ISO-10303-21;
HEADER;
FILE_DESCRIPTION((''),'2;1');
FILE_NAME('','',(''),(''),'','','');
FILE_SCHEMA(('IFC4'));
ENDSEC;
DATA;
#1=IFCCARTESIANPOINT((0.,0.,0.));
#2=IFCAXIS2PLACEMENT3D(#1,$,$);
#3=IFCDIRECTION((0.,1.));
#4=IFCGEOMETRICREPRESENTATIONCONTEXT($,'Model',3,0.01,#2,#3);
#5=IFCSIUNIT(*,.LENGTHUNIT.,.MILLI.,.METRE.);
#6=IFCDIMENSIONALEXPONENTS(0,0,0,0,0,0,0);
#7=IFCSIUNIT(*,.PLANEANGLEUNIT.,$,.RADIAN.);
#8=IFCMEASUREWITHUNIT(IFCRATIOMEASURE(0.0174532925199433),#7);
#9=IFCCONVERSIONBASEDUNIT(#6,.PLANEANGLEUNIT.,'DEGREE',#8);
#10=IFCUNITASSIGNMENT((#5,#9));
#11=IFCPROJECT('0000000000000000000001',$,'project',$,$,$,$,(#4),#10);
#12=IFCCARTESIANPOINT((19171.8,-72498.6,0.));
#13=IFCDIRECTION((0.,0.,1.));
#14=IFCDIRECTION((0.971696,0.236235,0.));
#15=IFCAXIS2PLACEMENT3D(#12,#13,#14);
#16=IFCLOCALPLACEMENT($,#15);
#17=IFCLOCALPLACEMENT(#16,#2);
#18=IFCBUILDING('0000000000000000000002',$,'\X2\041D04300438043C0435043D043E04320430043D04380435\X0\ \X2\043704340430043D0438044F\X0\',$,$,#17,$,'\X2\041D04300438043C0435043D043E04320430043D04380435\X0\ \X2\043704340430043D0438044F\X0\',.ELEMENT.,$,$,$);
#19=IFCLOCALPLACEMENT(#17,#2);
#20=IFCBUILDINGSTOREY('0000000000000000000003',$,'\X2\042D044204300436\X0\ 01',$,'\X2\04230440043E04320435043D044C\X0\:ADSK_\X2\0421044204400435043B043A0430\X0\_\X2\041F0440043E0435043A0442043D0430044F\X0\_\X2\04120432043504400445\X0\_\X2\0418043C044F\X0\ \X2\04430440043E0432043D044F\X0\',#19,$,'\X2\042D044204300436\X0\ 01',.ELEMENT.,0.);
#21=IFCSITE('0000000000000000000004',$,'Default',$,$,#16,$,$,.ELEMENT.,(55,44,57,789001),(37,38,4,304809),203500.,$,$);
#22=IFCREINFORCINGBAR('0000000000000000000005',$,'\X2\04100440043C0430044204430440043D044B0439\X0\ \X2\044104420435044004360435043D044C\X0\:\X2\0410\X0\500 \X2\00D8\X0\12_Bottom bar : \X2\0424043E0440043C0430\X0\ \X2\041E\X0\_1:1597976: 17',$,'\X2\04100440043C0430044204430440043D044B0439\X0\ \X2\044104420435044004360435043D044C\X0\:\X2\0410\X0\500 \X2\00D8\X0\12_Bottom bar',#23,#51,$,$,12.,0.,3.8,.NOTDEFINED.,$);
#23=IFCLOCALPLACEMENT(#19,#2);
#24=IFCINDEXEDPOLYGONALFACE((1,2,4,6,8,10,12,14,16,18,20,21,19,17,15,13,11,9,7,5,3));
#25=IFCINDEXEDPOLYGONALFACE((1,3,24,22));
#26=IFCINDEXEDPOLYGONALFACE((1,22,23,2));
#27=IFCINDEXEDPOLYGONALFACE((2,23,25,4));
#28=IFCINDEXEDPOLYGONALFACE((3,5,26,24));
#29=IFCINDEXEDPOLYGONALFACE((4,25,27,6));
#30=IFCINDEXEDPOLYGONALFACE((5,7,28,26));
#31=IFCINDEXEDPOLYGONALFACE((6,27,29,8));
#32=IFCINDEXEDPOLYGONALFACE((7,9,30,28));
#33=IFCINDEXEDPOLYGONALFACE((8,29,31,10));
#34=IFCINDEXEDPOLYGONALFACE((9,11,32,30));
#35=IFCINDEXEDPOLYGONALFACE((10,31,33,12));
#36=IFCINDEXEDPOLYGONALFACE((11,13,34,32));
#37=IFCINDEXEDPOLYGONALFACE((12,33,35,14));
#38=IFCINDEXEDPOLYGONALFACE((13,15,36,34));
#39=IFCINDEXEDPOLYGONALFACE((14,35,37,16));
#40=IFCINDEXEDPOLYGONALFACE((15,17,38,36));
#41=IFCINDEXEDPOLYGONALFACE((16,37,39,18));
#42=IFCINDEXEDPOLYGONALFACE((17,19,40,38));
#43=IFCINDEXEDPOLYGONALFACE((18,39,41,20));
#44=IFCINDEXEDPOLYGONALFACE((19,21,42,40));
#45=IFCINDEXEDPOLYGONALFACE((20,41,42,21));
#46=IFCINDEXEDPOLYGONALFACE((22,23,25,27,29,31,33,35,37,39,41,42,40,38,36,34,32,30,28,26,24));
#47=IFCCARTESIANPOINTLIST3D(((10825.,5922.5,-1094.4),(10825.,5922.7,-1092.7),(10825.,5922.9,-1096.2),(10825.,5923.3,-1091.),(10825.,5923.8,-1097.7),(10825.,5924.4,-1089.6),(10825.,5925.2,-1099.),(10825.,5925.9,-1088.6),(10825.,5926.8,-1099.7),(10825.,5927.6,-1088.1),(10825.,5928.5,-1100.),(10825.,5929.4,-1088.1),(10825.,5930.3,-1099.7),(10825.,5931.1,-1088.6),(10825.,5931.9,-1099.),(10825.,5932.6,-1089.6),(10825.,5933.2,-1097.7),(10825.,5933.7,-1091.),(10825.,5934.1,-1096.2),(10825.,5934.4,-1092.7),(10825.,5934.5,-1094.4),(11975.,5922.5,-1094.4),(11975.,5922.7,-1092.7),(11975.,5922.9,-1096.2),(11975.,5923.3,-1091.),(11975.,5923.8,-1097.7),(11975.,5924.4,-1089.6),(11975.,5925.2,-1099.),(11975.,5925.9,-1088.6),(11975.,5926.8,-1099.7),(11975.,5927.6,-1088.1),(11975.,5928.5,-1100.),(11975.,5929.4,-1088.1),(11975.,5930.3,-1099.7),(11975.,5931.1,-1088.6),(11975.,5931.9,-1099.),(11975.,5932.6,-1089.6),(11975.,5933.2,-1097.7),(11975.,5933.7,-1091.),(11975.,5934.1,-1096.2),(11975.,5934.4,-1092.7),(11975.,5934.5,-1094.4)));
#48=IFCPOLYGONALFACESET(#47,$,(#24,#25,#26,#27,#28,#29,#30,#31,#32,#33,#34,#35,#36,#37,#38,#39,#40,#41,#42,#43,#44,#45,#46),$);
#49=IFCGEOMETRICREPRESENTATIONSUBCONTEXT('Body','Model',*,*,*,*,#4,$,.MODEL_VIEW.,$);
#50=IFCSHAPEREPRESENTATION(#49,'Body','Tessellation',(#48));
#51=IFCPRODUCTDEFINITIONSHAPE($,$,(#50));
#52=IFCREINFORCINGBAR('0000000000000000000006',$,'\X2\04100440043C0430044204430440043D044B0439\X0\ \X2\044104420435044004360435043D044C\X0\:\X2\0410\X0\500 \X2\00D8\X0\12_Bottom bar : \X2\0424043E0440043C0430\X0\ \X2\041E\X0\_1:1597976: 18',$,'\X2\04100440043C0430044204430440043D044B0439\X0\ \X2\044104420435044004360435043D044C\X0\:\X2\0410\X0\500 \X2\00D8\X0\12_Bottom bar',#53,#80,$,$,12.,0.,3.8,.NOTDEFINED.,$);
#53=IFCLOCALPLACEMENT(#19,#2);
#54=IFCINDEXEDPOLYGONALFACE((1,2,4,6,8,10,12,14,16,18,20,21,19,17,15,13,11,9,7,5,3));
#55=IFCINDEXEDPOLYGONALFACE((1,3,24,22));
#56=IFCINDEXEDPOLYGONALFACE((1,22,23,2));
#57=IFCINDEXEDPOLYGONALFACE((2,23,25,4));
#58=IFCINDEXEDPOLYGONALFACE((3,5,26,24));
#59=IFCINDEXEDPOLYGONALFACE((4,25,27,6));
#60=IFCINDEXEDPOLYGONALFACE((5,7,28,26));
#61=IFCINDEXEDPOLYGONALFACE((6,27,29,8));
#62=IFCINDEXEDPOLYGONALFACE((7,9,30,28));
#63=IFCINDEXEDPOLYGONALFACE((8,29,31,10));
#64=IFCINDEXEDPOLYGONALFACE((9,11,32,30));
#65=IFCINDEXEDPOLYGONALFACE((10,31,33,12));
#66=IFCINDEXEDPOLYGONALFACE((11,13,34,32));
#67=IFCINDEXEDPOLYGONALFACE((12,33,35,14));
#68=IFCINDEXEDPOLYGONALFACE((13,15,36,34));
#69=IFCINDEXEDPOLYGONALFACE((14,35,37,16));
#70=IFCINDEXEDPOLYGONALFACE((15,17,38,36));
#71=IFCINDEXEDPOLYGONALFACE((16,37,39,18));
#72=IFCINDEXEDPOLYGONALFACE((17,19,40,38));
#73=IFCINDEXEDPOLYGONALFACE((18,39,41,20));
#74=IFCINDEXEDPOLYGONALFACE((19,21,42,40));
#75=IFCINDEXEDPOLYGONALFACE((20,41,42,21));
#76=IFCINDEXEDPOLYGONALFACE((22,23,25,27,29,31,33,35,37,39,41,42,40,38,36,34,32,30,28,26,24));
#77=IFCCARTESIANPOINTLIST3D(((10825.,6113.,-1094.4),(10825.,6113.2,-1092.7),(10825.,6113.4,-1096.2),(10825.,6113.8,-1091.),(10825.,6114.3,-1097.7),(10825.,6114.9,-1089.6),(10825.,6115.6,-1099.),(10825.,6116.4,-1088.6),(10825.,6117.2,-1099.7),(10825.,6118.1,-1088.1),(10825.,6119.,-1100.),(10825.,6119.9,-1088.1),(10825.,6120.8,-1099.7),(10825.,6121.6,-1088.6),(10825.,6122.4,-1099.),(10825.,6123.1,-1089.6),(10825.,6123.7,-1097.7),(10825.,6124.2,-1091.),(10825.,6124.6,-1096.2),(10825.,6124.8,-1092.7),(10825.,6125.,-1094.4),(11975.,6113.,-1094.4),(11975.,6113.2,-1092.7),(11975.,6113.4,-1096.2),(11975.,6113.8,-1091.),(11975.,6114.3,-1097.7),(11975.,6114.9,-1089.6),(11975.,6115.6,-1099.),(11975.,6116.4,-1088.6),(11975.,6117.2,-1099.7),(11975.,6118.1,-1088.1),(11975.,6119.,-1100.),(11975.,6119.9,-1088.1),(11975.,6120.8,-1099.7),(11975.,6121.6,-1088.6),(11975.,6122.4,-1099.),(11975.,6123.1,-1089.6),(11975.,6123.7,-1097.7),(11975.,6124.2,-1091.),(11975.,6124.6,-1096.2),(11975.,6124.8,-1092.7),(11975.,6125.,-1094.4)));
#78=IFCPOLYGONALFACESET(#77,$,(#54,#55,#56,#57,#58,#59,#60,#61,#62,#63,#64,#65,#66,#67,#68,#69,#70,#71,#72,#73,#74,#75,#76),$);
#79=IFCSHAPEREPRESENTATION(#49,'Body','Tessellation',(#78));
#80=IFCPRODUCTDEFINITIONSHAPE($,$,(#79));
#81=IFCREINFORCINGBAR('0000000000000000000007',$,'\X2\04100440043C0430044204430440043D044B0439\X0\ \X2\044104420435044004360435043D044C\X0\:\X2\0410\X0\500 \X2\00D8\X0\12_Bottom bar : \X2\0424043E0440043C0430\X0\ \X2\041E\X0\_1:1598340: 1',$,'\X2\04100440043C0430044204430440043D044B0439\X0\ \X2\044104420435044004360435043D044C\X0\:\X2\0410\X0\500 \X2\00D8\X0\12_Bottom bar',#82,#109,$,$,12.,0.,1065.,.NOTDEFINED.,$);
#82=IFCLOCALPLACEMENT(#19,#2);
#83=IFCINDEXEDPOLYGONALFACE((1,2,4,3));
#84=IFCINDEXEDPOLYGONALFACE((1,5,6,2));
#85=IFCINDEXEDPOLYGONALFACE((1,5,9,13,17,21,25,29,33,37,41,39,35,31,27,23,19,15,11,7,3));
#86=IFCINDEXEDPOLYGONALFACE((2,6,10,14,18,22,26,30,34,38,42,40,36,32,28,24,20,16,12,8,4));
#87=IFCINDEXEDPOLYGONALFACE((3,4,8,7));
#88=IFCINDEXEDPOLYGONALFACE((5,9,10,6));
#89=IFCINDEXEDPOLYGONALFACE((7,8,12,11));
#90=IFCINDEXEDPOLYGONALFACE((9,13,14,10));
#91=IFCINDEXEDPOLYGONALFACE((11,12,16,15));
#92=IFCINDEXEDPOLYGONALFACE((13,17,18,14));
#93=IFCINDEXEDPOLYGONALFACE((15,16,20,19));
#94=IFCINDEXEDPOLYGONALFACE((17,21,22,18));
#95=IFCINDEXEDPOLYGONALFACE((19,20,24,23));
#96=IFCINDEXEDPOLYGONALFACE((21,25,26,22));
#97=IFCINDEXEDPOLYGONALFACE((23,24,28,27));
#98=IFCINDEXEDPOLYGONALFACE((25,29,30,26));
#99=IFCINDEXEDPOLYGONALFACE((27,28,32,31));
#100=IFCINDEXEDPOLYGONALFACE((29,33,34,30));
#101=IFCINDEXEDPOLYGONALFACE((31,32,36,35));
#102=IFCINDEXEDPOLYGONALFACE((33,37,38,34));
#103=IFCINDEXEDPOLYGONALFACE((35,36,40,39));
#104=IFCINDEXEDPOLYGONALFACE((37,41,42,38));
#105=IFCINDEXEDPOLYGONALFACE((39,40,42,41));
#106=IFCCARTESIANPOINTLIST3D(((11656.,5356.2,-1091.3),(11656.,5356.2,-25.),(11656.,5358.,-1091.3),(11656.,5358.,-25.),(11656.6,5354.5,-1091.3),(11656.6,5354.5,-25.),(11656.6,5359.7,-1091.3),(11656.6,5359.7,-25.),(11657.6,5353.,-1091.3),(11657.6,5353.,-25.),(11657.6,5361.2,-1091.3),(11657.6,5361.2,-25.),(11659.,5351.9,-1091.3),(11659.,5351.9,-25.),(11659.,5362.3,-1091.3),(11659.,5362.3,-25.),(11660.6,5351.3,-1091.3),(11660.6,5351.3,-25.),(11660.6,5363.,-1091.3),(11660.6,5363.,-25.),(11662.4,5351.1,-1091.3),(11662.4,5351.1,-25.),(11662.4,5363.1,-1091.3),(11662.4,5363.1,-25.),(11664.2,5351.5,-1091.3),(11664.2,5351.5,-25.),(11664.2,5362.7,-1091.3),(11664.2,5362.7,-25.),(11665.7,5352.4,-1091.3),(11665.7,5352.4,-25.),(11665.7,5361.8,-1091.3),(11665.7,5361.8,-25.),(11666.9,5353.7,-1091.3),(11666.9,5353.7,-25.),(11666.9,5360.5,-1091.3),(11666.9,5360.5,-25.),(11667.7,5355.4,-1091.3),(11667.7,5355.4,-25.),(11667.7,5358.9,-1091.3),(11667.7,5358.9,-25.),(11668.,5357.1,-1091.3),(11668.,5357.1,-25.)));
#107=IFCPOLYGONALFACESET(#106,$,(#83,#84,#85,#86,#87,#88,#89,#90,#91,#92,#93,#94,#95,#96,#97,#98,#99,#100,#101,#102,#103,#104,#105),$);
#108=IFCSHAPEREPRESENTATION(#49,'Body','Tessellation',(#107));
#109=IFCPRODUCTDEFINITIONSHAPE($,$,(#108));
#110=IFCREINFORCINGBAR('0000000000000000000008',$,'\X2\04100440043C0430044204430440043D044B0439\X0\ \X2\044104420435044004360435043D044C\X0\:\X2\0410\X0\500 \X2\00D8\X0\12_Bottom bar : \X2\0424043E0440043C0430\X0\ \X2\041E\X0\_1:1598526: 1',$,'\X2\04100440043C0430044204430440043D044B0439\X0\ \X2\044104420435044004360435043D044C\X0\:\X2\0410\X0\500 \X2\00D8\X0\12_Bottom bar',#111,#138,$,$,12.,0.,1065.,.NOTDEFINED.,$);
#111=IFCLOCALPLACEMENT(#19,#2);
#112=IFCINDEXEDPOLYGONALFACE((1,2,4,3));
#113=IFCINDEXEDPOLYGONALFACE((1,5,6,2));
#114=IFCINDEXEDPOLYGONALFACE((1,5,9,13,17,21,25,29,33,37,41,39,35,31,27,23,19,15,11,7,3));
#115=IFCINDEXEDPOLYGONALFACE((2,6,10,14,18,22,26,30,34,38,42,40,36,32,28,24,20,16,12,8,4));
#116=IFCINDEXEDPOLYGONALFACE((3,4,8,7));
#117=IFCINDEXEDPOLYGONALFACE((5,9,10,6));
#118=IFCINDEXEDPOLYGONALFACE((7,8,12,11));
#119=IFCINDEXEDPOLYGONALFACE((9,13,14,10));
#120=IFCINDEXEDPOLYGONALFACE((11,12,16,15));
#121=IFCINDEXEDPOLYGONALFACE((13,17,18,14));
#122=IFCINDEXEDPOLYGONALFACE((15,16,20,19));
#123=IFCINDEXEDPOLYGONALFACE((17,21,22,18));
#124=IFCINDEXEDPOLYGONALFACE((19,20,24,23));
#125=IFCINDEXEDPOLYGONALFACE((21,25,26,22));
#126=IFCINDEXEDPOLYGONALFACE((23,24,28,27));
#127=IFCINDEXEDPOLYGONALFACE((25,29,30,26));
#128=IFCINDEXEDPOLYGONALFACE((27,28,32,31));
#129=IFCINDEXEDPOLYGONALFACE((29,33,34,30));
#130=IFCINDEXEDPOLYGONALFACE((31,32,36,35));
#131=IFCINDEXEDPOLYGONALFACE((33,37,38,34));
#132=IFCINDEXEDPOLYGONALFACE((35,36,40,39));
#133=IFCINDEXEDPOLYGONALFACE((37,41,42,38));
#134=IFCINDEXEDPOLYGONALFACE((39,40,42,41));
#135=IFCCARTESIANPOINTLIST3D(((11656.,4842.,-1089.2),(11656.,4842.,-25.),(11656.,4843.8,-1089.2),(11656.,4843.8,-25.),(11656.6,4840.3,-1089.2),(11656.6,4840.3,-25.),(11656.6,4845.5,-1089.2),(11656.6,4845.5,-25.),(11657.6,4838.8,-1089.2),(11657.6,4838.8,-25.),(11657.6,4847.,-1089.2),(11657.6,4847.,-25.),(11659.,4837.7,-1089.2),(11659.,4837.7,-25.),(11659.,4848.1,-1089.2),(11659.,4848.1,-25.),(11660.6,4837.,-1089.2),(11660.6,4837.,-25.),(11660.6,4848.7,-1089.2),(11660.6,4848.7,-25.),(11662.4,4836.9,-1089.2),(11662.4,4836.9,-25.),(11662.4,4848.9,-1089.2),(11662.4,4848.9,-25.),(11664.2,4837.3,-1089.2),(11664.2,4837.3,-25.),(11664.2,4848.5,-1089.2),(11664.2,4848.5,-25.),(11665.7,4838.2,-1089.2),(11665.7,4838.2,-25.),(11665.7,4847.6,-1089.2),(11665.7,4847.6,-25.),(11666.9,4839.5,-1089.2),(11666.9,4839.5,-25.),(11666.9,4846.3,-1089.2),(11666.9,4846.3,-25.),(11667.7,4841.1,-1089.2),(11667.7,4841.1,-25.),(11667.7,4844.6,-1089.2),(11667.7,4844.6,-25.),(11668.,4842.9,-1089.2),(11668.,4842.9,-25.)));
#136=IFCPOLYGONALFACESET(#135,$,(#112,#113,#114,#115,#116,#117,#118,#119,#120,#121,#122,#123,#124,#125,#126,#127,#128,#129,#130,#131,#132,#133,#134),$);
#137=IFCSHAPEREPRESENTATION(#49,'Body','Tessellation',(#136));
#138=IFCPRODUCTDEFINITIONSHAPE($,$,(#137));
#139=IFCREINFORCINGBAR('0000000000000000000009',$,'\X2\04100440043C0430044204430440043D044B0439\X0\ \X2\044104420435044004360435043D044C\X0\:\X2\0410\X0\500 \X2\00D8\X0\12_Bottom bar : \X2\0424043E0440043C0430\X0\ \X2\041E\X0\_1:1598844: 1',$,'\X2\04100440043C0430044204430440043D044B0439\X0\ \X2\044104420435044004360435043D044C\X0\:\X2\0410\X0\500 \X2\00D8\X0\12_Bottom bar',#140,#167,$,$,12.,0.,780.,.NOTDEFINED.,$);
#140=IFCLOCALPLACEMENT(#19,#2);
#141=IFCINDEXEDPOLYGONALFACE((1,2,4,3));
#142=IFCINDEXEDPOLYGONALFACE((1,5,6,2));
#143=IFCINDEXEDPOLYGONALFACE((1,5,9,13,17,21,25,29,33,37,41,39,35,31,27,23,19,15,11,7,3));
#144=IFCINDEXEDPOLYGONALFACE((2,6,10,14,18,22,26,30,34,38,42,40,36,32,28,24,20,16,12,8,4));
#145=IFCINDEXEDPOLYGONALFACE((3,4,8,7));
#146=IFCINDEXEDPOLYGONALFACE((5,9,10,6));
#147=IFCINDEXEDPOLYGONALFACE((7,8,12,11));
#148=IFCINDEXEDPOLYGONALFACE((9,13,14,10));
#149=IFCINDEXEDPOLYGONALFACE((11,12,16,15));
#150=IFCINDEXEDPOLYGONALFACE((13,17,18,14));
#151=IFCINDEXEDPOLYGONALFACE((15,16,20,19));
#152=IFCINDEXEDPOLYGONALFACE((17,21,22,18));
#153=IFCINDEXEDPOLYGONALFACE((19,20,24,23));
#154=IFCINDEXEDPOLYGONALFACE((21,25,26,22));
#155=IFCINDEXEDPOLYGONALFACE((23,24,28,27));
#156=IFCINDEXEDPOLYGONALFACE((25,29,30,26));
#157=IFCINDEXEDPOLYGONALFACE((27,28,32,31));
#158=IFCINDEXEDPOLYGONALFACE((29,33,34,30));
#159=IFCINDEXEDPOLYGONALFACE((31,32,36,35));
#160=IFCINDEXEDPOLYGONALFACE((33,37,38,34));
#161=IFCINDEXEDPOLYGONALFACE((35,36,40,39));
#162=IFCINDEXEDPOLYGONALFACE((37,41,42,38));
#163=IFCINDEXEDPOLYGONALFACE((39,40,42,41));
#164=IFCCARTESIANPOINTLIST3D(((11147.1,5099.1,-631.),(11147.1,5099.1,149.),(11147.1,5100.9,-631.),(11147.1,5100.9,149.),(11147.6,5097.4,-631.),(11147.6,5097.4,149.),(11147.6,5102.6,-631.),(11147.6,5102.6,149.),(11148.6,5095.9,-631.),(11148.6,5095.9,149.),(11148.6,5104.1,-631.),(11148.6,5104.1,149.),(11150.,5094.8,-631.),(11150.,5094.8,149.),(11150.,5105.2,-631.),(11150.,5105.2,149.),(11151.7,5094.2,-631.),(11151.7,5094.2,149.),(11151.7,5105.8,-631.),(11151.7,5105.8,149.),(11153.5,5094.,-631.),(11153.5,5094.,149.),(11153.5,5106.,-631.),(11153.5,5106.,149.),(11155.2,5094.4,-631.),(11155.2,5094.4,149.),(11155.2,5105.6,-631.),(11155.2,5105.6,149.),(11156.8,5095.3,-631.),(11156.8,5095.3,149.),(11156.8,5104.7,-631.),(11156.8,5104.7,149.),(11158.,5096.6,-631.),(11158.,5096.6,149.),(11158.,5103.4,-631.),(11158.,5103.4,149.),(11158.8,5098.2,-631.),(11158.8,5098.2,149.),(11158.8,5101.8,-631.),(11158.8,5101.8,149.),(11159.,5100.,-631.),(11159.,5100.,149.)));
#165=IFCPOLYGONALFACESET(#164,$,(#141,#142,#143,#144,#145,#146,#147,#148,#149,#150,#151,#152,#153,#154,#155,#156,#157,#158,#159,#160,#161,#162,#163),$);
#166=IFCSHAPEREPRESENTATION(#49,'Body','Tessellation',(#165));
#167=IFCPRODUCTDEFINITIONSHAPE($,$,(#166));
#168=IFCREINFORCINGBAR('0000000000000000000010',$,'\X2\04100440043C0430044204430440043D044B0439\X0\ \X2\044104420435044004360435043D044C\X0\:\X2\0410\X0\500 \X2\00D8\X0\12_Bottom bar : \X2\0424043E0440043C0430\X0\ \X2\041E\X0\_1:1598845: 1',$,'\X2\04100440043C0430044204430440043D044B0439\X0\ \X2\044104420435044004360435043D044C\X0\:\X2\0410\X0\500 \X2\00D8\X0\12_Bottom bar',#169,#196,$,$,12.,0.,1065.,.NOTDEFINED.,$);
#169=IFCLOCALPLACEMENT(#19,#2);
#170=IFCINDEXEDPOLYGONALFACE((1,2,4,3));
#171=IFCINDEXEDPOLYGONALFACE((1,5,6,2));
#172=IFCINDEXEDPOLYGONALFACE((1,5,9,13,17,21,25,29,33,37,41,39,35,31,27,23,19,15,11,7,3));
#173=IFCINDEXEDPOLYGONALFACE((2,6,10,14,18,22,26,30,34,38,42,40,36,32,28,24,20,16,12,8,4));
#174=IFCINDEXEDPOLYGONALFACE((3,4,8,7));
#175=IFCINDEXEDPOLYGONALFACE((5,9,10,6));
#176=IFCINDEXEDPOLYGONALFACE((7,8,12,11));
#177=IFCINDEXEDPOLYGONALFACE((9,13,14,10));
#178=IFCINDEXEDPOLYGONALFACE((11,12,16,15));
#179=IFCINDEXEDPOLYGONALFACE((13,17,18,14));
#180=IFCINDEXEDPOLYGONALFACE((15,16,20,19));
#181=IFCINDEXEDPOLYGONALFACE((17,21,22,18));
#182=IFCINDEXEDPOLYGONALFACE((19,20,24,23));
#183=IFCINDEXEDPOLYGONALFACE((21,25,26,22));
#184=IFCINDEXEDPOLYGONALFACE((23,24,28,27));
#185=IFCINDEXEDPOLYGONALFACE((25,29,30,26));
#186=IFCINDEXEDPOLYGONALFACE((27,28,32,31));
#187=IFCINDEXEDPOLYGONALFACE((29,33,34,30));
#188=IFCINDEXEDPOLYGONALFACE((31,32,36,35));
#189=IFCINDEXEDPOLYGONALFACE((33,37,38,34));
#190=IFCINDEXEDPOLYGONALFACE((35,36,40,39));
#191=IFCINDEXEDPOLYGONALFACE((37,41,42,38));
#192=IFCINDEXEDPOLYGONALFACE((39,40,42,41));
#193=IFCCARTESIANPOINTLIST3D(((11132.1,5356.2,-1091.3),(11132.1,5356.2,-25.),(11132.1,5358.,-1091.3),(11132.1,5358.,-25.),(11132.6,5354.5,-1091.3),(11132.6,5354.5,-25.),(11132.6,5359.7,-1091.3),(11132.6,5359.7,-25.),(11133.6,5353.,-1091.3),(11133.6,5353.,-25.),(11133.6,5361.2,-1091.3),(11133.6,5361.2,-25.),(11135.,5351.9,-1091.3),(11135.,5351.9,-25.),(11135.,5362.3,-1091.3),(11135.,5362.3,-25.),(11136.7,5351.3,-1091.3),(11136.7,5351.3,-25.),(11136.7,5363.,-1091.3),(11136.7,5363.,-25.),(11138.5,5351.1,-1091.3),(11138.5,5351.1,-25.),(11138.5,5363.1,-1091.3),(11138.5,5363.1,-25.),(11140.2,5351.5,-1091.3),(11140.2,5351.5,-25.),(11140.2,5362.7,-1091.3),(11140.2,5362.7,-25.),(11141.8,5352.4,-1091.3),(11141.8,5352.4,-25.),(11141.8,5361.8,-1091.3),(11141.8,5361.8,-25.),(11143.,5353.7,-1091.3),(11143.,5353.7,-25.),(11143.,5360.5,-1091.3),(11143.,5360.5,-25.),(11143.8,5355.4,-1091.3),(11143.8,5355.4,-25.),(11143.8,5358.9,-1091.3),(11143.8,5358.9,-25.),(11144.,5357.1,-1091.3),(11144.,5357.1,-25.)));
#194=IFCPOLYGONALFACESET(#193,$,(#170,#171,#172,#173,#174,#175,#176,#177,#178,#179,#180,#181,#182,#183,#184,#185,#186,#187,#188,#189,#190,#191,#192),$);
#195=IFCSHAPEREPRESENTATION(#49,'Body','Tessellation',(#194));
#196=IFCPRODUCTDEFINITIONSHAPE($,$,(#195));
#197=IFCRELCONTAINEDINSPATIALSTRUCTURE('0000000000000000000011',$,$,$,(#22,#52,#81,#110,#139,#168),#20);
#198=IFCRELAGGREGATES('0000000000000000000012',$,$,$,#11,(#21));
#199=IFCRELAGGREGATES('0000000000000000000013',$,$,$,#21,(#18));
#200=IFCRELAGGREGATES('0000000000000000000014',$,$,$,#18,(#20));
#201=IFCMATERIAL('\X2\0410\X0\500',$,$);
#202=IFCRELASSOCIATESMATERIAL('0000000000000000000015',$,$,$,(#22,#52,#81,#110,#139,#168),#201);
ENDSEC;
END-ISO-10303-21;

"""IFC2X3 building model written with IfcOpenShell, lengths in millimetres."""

from ifc_helpers import new_model, entity, si_unit, converted_unit, direction, frame, origin, place, context, subcontext, project, spatial, material, element, save


model = new_model("IFC2X3")

# Units and contexts
model_context = context("Model", 3, precision=0.01, world=origin(), true_north=direction((0.0, 1.0)))
body_context = subcontext(model_context, "Body", "Model", "MODEL_VIEW")
ifc_project = project(units=[si_unit("LENGTHUNIT", "METRE", prefix="MILLI"), converted_unit("PLANEANGLEUNIT", "DEGREE", entity("IfcRatioMeasure", 0.0174532925199433), si_unit("PLANEANGLEUNIT", "RADIAN"), dimensions=[0, 0, 0, 0, 0, 0, 0])], contexts=[model_context])

# Site, building, storey
site_placement = place(None, frame((19171.8, -72498.6, 0.0), z_axis=(0.0, 0.0, 1.0), x_axis=(0.971696, 0.236235, 0.0)))
site = spatial("IfcSite", under=ifc_project, at=site_placement, Name="Default", CompositionType="ELEMENT", RefLatitude=(55, 44, 57, 789001), RefLongitude=(37, 38, 4, 304809), RefElevation=203500.0)
building_placement = place(site_placement, origin())
building = spatial("IfcBuilding", under=site, at=building_placement, Name="Наименование здания", LongName="Наименование здания", CompositionType="ELEMENT")
storey_placement = place(building_placement, origin())
storey = spatial("IfcBuildingStorey", under=building, at=storey_placement, Name="Этаж 01", ObjectType="Уровень:ADSK_Стрелка_Проектная_Вверх_Имя уровня", LongName="Этаж 01", CompositionType="ELEMENT", Elevation=0.0)

# Reinforcing bars
ifc_material = material(Name="А500")
placement = place(storey_placement, origin())
element("IfcReinforcingBar", 1, at=placement, inside=storey, material=ifc_material, Name="Арматурный стержень:А500 Ø12_Bottom bar : Форма О_1:1597976: 17", ObjectType="Арматурный стержень:А500 Ø12_Bottom bar", BarLength=3.8, BarRole="NOTDEFINED", CrossSectionArea=0.0, NominalDiameter=12.0, context=body_context, shape_type="AdvancedSweptSolid", body=[
    entity("IfcSweptDiskSolid", entity("IfcCompositeCurve", [entity("IfcCompositeCurveSegment", "CONTINUOUS", True, entity("IfcPolyline", [entity("IfcCartesianPoint", [11975.0, 5928.5, -1094.0]), entity("IfcCartesianPoint", [10825.0, 5928.5, -1094.0])]))], False), 6.0, None, 0.0, 1.0),
])
element("IfcReinforcingBar", 2, at=placement, inside=storey, material=ifc_material, Name="Арматурный стержень:А500 Ø12_Bottom bar : Форма О_1:1597976: 18", ObjectType="Арматурный стержень:А500 Ø12_Bottom bar", BarLength=3.8, BarRole="NOTDEFINED", CrossSectionArea=0.0, NominalDiameter=12.0, context=body_context, shape_type="AdvancedSweptSolid", body=[
    entity("IfcSweptDiskSolid", entity("IfcCompositeCurve", [entity("IfcCompositeCurveSegment", "CONTINUOUS", True, entity("IfcPolyline", [entity("IfcCartesianPoint", [11975.0, 6119.0, -1094.0]), entity("IfcCartesianPoint", [10825.0, 6119.0, -1094.0])]))], False), 6.0, None, 0.0, 1.0),
])
element("IfcReinforcingBar", 3, at=placement, inside=storey, material=ifc_material, Name="Арматурный стержень:А500 Ø12_Bottom bar : Форма О_1:1598340: 1", ObjectType="Арматурный стержень:А500 Ø12_Bottom bar", BarLength=1065.0, BarRole="NOTDEFINED", CrossSectionArea=0.0, NominalDiameter=12.0, context=body_context, shape_type="AdvancedSweptSolid", body=[
    entity("IfcSweptDiskSolid", entity("IfcCompositeCurve", [entity("IfcCompositeCurveSegment", "CONTINUOUS", True, entity("IfcPolyline", [entity("IfcCartesianPoint", [11662.0, 5357.1, -1091.3]), entity("IfcCartesianPoint", [11662.0, 5357.1, -25.0])]))], False), 6.0, None, 0.0, 1.0),
])
element("IfcReinforcingBar", 4, at=placement, inside=storey, material=ifc_material, Name="Арматурный стержень:А500 Ø12_Bottom bar : Форма О_1:1598526: 1", ObjectType="Арматурный стержень:А500 Ø12_Bottom bar", BarLength=1065.0, BarRole="NOTDEFINED", CrossSectionArea=0.0, NominalDiameter=12.0, context=body_context, shape_type="AdvancedSweptSolid", body=[
    entity("IfcSweptDiskSolid", entity("IfcCompositeCurve", [entity("IfcCompositeCurveSegment", "CONTINUOUS", True, entity("IfcPolyline", [entity("IfcCartesianPoint", [11662.0, 4842.9, -1089.2]), entity("IfcCartesianPoint", [11662.0, 4842.9, -25.0])]))], False), 6.0, None, 0.0, 1.0),
])
element("IfcReinforcingBar", 5, at=placement, inside=storey, material=ifc_material, Name="Арматурный стержень:А500 Ø12_Bottom bar : Форма О_1:1598844: 1", ObjectType="Арматурный стержень:А500 Ø12_Bottom bar", BarLength=780.0, BarRole="NOTDEFINED", CrossSectionArea=0.0, NominalDiameter=12.0, context=body_context, shape_type="AdvancedSweptSolid", body=[
    entity("IfcSweptDiskSolid", entity("IfcCompositeCurve", [entity("IfcCompositeCurveSegment", "CONTINUOUS", True, entity("IfcPolyline", [entity("IfcCartesianPoint", [11153.0, 5100.0, -631.0]), entity("IfcCartesianPoint", [11153.0, 5100.0, 149.0])]))], False), 6.0, None, 0.0, 1.0),
])
element("IfcReinforcingBar", 6, at=placement, inside=storey, material=ifc_material, Name="Арматурный стержень:А500 Ø12_Bottom bar : Форма О_1:1598845: 1", ObjectType="Арматурный стержень:А500 Ø12_Bottom bar", BarLength=1065.0, BarRole="NOTDEFINED", CrossSectionArea=0.0, NominalDiameter=12.0, context=body_context, shape_type="AdvancedSweptSolid", body=[
    entity("IfcSweptDiskSolid", entity("IfcCompositeCurve", [entity("IfcCompositeCurveSegment", "CONTINUOUS", True, entity("IfcPolyline", [entity("IfcCartesianPoint", [11138.0, 5357.1, -1091.3]), entity("IfcCartesianPoint", [11138.0, 5357.1, -25.0])]))], False), 6.0, None, 0.0, 1.0),
])

save(model, "model.ifc")
